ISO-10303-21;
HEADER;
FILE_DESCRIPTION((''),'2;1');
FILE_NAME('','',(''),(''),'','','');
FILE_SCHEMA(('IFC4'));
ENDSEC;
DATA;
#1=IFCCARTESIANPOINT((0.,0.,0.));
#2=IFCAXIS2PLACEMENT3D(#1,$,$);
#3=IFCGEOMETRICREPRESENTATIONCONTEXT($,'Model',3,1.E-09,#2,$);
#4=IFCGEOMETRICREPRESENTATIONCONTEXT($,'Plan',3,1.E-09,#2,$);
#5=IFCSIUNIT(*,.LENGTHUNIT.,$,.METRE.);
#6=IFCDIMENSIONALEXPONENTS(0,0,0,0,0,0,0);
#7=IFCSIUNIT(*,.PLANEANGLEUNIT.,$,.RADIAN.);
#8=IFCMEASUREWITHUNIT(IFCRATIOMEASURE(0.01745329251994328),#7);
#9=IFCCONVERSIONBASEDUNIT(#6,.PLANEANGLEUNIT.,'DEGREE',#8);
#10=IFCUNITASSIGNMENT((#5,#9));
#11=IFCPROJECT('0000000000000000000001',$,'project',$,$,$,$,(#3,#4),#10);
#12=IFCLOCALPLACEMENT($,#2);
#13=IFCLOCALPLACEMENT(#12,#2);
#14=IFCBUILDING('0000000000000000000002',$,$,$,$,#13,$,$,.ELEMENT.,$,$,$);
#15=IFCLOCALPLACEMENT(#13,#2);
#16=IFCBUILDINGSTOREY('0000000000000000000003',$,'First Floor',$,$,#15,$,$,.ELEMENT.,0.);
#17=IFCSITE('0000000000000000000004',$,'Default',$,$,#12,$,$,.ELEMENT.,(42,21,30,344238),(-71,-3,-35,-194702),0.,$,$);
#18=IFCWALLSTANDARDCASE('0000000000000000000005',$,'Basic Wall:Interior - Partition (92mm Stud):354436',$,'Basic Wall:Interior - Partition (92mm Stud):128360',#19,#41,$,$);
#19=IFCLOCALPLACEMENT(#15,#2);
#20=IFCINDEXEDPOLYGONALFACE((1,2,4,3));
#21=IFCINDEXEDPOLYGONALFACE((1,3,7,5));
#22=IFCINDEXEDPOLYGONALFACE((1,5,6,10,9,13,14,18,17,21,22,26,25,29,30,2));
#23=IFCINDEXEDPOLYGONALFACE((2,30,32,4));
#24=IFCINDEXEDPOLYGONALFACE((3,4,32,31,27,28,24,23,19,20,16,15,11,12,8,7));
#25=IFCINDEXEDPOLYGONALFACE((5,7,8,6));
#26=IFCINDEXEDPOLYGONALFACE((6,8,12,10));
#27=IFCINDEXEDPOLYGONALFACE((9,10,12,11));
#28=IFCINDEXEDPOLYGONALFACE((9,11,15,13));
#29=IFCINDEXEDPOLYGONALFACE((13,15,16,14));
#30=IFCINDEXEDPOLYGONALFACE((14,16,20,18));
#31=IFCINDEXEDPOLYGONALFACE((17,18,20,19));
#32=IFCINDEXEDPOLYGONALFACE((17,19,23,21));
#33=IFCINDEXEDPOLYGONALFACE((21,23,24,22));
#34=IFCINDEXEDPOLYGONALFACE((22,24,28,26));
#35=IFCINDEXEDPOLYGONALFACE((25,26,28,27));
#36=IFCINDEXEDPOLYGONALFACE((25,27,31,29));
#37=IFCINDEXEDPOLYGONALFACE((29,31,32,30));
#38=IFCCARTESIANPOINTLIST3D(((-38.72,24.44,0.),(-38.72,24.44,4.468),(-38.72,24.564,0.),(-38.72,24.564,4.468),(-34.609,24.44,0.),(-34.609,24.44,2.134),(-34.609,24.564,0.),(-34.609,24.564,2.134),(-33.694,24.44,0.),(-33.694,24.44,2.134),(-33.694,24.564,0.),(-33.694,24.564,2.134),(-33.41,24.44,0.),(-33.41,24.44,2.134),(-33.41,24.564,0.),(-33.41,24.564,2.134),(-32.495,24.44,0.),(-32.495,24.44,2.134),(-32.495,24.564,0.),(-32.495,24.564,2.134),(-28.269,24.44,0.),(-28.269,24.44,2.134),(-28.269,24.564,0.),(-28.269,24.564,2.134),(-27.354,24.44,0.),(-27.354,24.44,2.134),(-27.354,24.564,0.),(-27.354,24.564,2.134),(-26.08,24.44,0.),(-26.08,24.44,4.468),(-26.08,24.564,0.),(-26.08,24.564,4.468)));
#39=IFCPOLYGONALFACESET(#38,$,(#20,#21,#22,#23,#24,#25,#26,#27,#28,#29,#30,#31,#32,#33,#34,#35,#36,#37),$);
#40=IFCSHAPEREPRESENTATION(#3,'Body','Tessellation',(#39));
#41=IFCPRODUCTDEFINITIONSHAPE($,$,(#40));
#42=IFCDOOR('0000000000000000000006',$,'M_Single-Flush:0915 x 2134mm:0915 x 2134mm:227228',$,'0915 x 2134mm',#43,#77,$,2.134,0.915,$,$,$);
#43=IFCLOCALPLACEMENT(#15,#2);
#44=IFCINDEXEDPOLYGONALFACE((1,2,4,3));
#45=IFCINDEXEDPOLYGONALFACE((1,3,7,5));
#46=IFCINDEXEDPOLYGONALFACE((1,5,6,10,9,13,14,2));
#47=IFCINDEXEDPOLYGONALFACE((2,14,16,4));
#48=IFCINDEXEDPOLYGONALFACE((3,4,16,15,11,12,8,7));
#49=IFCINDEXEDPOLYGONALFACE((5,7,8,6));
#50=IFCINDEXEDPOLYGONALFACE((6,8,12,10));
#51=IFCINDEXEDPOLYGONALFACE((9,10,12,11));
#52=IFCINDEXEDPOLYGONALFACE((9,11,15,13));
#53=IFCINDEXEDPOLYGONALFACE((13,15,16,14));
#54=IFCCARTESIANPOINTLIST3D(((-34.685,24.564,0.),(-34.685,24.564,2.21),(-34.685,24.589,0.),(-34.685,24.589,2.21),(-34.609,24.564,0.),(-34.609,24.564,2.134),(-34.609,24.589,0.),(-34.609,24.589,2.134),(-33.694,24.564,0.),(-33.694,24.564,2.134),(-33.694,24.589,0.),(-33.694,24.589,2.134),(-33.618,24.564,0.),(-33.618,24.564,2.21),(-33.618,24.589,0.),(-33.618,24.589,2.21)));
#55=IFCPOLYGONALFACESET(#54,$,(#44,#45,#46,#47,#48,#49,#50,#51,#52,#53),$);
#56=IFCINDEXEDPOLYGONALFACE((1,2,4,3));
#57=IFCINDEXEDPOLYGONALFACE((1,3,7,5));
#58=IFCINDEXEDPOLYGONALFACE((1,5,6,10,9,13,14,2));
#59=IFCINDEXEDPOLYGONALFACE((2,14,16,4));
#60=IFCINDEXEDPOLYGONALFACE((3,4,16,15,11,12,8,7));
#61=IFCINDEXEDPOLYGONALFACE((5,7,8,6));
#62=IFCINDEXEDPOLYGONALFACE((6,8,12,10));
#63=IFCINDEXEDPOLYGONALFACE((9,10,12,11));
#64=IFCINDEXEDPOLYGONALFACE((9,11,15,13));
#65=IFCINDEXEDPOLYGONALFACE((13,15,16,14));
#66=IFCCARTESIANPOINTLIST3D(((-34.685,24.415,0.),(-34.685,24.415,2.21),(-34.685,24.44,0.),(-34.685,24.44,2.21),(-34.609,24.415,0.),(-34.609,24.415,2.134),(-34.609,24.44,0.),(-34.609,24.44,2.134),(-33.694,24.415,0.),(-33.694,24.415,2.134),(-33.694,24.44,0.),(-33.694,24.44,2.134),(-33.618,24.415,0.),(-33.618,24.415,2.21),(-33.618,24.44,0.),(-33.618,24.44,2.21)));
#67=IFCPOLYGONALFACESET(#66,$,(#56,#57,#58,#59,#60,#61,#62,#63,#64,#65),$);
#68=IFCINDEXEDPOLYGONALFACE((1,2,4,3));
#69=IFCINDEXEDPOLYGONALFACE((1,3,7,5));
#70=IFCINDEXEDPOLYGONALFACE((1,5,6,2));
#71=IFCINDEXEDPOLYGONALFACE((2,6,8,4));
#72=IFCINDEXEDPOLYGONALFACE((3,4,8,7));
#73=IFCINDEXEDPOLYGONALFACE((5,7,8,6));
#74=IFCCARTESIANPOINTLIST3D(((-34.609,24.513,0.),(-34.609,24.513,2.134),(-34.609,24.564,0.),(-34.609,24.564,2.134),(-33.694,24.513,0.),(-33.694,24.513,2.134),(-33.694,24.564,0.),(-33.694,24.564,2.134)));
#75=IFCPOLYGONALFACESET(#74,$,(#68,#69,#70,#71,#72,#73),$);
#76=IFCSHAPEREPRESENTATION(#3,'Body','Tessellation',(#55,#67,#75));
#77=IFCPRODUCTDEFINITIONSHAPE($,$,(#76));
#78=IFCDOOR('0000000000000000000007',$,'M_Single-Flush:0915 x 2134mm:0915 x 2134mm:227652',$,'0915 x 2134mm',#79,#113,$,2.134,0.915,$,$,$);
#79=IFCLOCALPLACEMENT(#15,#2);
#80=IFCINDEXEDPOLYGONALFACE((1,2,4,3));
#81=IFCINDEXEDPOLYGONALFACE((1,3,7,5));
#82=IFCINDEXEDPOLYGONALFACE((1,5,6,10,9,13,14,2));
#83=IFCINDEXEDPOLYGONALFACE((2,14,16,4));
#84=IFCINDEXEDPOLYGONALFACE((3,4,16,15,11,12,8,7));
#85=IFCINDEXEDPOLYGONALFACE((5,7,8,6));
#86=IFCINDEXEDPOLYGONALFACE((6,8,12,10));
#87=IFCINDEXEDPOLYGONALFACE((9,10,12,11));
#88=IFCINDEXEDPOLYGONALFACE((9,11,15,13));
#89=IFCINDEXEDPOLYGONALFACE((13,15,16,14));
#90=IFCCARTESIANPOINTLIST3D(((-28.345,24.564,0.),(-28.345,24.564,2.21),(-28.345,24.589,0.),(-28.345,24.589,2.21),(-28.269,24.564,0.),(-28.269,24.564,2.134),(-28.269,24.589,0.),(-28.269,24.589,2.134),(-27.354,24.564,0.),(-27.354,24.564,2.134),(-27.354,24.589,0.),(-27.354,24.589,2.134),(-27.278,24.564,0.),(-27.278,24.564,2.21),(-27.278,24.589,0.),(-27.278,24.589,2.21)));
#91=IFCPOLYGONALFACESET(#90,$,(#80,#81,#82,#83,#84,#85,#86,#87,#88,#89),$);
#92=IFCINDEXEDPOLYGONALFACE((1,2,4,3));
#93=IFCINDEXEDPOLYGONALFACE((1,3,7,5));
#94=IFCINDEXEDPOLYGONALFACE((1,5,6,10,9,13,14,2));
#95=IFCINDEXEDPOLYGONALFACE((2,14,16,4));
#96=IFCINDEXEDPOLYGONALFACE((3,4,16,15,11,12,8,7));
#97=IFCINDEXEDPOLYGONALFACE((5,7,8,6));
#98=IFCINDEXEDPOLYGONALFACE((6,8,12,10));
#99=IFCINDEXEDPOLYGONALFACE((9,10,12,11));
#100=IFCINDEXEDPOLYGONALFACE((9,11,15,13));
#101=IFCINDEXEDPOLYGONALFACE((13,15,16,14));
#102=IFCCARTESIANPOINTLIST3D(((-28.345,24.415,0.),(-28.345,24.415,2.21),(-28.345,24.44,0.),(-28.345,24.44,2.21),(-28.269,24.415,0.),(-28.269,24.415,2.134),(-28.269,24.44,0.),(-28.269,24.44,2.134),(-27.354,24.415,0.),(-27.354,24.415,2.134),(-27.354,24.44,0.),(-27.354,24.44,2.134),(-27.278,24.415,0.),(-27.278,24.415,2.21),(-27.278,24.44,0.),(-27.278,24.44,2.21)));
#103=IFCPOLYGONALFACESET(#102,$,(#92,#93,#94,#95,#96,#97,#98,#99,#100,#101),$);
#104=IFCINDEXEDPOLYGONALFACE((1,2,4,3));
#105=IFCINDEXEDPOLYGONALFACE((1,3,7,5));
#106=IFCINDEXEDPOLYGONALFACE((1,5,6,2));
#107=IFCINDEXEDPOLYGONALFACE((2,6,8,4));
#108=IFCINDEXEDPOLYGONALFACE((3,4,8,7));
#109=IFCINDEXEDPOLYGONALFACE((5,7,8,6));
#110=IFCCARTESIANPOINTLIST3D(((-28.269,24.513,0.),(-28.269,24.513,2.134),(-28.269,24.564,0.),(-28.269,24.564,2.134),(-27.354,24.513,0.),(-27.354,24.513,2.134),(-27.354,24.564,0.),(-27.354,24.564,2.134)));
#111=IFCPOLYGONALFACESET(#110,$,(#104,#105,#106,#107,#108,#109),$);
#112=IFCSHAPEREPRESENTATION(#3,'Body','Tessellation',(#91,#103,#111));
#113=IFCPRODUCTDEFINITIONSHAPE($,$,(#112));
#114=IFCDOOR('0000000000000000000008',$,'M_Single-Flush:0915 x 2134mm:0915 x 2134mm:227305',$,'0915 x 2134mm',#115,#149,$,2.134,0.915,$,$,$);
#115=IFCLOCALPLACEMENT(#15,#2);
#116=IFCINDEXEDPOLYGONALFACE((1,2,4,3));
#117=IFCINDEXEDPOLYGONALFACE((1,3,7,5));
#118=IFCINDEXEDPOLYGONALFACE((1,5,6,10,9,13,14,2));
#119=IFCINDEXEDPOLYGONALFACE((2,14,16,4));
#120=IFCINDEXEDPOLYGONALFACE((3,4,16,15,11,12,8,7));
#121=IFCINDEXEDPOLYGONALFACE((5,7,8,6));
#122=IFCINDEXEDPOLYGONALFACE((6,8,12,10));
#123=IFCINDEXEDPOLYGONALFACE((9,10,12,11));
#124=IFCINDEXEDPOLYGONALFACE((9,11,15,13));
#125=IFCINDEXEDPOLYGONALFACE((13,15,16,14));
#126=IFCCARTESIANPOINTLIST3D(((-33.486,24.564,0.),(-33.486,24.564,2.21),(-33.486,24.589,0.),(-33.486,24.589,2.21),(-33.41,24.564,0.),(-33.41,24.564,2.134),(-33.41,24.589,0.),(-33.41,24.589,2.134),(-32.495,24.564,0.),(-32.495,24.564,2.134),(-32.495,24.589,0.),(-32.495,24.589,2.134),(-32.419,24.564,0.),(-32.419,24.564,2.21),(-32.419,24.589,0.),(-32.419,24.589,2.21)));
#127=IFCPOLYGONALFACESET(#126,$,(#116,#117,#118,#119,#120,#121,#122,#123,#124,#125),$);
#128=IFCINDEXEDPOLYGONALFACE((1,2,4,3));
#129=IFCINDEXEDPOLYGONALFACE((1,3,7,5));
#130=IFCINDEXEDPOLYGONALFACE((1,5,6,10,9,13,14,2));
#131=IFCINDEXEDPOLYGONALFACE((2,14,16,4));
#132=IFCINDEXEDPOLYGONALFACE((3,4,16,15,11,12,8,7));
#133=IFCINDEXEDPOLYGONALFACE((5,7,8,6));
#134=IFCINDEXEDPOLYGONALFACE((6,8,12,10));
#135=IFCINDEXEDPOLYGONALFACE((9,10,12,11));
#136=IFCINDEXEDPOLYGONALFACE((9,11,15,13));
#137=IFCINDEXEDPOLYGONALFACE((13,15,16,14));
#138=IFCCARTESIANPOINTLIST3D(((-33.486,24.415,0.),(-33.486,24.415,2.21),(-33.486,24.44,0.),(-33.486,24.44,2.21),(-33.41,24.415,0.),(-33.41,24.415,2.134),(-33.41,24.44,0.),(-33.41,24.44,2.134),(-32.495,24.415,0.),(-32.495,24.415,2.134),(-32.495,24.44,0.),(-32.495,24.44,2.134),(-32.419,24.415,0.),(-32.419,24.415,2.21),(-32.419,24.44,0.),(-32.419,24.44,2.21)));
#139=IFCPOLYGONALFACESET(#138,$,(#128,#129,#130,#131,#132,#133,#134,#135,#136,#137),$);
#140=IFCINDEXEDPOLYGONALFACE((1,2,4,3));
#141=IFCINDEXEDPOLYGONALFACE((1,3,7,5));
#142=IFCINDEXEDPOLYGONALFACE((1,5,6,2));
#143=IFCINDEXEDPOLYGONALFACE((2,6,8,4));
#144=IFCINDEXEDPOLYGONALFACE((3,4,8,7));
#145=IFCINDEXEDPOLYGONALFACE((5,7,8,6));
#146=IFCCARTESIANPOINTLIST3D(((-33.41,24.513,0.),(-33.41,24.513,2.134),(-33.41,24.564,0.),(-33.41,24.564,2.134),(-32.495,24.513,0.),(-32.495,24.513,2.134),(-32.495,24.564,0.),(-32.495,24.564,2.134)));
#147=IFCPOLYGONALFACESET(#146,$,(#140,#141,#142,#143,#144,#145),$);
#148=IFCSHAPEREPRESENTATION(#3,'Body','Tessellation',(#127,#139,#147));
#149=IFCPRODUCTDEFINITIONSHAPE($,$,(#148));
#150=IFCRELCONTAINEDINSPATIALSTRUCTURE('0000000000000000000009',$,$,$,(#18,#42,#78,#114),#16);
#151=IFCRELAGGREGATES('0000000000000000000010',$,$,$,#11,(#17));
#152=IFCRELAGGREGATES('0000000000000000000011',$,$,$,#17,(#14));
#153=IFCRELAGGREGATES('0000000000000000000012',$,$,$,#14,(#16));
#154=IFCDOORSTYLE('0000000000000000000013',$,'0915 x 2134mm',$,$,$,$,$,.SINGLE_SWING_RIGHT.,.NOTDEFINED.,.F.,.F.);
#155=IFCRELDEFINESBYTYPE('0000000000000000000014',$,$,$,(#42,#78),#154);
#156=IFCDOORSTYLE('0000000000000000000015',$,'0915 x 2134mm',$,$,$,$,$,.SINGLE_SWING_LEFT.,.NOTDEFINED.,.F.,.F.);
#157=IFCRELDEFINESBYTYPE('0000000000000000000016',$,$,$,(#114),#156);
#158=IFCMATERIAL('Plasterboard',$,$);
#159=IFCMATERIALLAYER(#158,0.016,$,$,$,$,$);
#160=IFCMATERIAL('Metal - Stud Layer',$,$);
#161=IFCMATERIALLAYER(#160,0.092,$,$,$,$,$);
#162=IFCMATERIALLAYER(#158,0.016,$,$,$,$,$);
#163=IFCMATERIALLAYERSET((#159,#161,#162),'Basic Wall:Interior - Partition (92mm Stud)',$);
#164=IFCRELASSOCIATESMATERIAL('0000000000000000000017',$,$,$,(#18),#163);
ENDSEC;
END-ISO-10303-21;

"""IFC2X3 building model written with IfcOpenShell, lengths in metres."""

from ifc_helpers import new_model, entity, si_unit, converted_unit, frame, frame_2d, origin, origin_2d_with_axis, place, context, project, spatial, polyline, rectangle, outline, extrude, source, transform, mapped, material, layer, layer_set, layer_usage, type_object, type_shapes, element, fill, save


model = new_model("IFC2X3")

# Units and contexts
model_context = context("Model", 3, precision=1e-09, world=origin())
plan_context = context("Plan", 3, precision=1e-09, world=origin())
ifc_project = project(units=[si_unit("LENGTHUNIT", "METRE"), converted_unit("PLANEANGLEUNIT", "DEGREE", entity("IfcRatioMeasure", 0.01745329251994328), si_unit("PLANEANGLEUNIT", "RADIAN"), dimensions=[0, 0, 0, 0, 0, 0, 0])], contexts=[model_context, plan_context])

# Site, building, storey
site_placement = place(None, origin())
site = spatial("IfcSite", under=ifc_project, at=site_placement, Name="Default", CompositionType="ELEMENT", RefLatitude=(42, 21, 30, 344238), RefLongitude=(-71, -3, -35, -194702), RefElevation=0.0)
building_placement = place(site_placement, origin())
building = spatial("IfcBuilding", under=site, at=building_placement, CompositionType="ELEMENT")
storey_placement = place(building_placement, origin())
storey = spatial("IfcBuildingStorey", under=building, at=storey_placement, Name="First Floor", CompositionType="ELEMENT", Elevation=0.0)

# Shared definitions
ifc_material_1 = material(Name="Plasterboard")
ifc_layer_1 = layer(ifc_material_1, 0.016)
ifc_material_2 = material(Name="Metal - Stud Layer")
ifc_layer_2 = layer(ifc_material_2, 0.092)
ifc_layer_3 = layer(ifc_material_1, 0.016)
ifc_layer_set_1 = layer_set([ifc_layer_1, ifc_layer_2, ifc_layer_3], Name="Basic Wall:Interior - Partition (92mm Stud)")
door_style_1 = type_object("IfcDoorStyle", Name="0915 x 2134mm", ConstructionType="NOTDEFINED", OperationType="SINGLE_SWING_RIGHT", ParameterTakesPrecedence=False, Sizeable=False)
shared_shape_1 = source(origin(), model_context, "Body", "SweptSolid", [
    extrude(outline(polyline([(-0.5335, -1.124), (0.5335, -1.124), (0.5335, 1.086), (0.4575, 1.086), (0.4575, -1.048), (-0.4575, -1.048), (-0.4575, 1.086), (-0.5335, 1.086), (-0.5335, -1.124)])), frame((0.4575, 0.124, 1.086), z_axis=(0.0, 1.0, 0.0), x_axis=(1.0, 0.0, 0.0)), (0.0, 0.0, 1.0), 0.025),
    extrude(outline(polyline([(-1.124, -0.5335), (1.086, -0.5335), (1.086, -0.4575), (-1.048, -0.4575), (-1.048, 0.4575), (1.086, 0.4575), (1.086, 0.5335), (-1.124, 0.5335), (-1.124, -0.5335)])), frame((0.4575, -0.025, 1.086), z_axis=(0.0, 1.0, 0.0), x_axis=(0.0, 0.0, -1.0)), (0.0, 0.0, 1.0), 0.025),
    extrude(rectangle(XDim=0.051, YDim=0.915, at=origin_2d_with_axis()), frame((0.4575, 0.0985, 0.0), z_axis=(0.0, 0.0, 1.0), x_axis=(0.0, 1.0, 0.0)), (0.0, 0.0, 1.0), 2.134),
])
type_shapes(door_style_1, [shared_shape_1])
door_style_2 = type_object("IfcDoorStyle", Name="0915 x 2134mm", ConstructionType="NOTDEFINED", OperationType="SINGLE_SWING_LEFT", ParameterTakesPrecedence=False, Sizeable=False)
shared_shape_2 = source(origin(), model_context, "Body", "SweptSolid", [
    extrude(outline(polyline([(-0.5335, -1.124), (0.5335, -1.124), (0.5335, 1.086), (0.4575, 1.086), (0.4575, -1.048), (-0.4575, -1.048), (-0.4575, 1.086), (-0.5335, 1.086), (-0.5335, -1.124)])), frame((0.4575, 0.149, 1.086), z_axis=(0.0, -1.0, 0.0), x_axis=(-1.0, 0.0, 0.0)), (0.0, 0.0, 1.0), 0.025),
    extrude(outline(polyline([(-1.124, -0.5335), (1.086, -0.5335), (1.086, -0.4575), (-1.048, -0.4575), (-1.048, 0.4575), (1.086, 0.4575), (1.086, 0.5335), (-1.124, 0.5335), (-1.124, -0.5335)])), frame((0.4575, 0.0, 1.086), z_axis=(0.0, -1.0, 0.0), x_axis=(0.0, 0.0, -1.0)), (0.0, 0.0, 1.0), 0.025),
    extrude(rectangle(XDim=0.915, YDim=0.051, at=origin_2d_with_axis()), frame((0.4575, 0.0985, 0.0)), (0.0, 0.0, 1.0), 2.134),
])
type_shapes(door_style_2, [shared_shape_2])

# Wall, openings, doors
ifc_layer_usage_1 = layer_usage(ifc_layer_set_1, "AXIS2", "NEGATIVE", 0.062)
wall_1_placement = place(storey_placement, frame((-26.08, 24.502, 0.0), z_axis=(0.0, 0.0, 1.0), x_axis=(-1.0, 0.0, 0.0)))
wall_1 = element("IfcWallStandardCase", 1, at=wall_1_placement, inside=storey, material=ifc_layer_usage_1, Name="Basic Wall:Interior - Partition (92mm Stud):354436", ObjectType="Basic Wall:Interior - Partition (92mm Stud):128360", context=model_context, shape_type="SweptSolid", body=[
    extrude(rectangle(XDim=12.64, YDim=0.124, at=frame_2d((6.32, 0.0), x_axis=(-1.0, 0.0))), origin(), (0.0, 0.0, 1.0), 4.468),
])
opening_1_placement = place(wall_1_placement, frame((8.529, 0.062, 0.0)))
opening_1 = element("IfcOpeningElement", 2, at=opening_1_placement, cuts=wall_1, ObjectType="Opening", context=model_context, shape_type="SweptSolid", body=[
    extrude(rectangle(XDim=0.915, YDim=2.134, at=frame_2d((1.067, 0.4575), x_axis=(0.0, 1.0))), frame((0.0, 0.0, 0.0), z_axis=(0.0, -1.0, 0.0), x_axis=(0.0, 0.0, 1.0)), (0.0, 0.0, 1.0), 0.124),
])
opening_2_placement = place(wall_1_placement, frame((7.33, 0.062, 0.0)))
opening_2 = element("IfcOpeningElement", 3, at=opening_2_placement, cuts=wall_1, ObjectType="Opening", context=model_context, shape_type="SweptSolid", body=[
    extrude(rectangle(XDim=0.915, YDim=2.134, at=frame_2d((1.067, 0.4575), x_axis=(0.0, -1.0))), frame((0.0, 0.0, 0.0), z_axis=(0.0, -1.0, 0.0), x_axis=(0.0, 0.0, 1.0)), (0.0, 0.0, 1.0), 0.124),
])
opening_3_placement = place(wall_1_placement, frame((2.189, 0.062, 0.0)))
opening_3 = element("IfcOpeningElement", 4, at=opening_3_placement, cuts=wall_1, ObjectType="Opening", context=model_context, shape_type="SweptSolid", body=[
    extrude(rectangle(XDim=0.915, YDim=2.134, at=frame_2d((1.067, 0.4575), x_axis=(0.0, 1.0))), frame((0.0, 0.0, 0.0), z_axis=(0.0, -1.0, 0.0), x_axis=(0.0, 0.0, 1.0)), (0.0, 0.0, 1.0), 0.124),
])
door_1_placement = place(opening_1_placement, frame((0.0, 0.0, 0.0), z_axis=(0.0, 0.0, 1.0), x_axis=(-1.0, 0.0, 0.0)))
door_1 = element("IfcDoor", 5, at=door_1_placement, inside=storey, type_object=door_style_1, Name="M_Single-Flush:0915 x 2134mm:0915 x 2134mm:227228", ObjectType="0915 x 2134mm", OverallHeight=2.134, OverallWidth=0.915, context=model_context, shape_type="MappedRepresentation", body=[
    mapped(shared_shape_1, transform((0.0, 0.0, 0.0), scale=1.0)),
])
fill(opening_1, door_1)
door_2_placement = place(opening_3_placement, frame((0.0, 0.0, 0.0), z_axis=(0.0, 0.0, 1.0), x_axis=(-1.0, 0.0, 0.0)))
door_2 = element("IfcDoor", 6, at=door_2_placement, inside=storey, type_object=door_style_1, Name="M_Single-Flush:0915 x 2134mm:0915 x 2134mm:227652", ObjectType="0915 x 2134mm", OverallHeight=2.134, OverallWidth=0.915, context=model_context, shape_type="MappedRepresentation", body=[
    mapped(shared_shape_1, transform((0.0, 0.0, 0.0), scale=1.0)),
])
fill(opening_3, door_2)
door_3_placement = place(opening_2_placement, frame((0.0, 0.0, 0.0), z_axis=(0.0, 0.0, 1.0), x_axis=(-1.0, 0.0, 0.0)))
door_3 = element("IfcDoor", 7, at=door_3_placement, inside=storey, type_object=door_style_2, Name="M_Single-Flush:0915 x 2134mm:0915 x 2134mm:227305", ObjectType="0915 x 2134mm", OverallHeight=2.134, OverallWidth=0.915, context=model_context, shape_type="MappedRepresentation", body=[
    mapped(shared_shape_2, transform((0.0, 0.0, 0.0), scale=1.0)),
])
fill(opening_2, door_3)

save(model, "model.ifc")
